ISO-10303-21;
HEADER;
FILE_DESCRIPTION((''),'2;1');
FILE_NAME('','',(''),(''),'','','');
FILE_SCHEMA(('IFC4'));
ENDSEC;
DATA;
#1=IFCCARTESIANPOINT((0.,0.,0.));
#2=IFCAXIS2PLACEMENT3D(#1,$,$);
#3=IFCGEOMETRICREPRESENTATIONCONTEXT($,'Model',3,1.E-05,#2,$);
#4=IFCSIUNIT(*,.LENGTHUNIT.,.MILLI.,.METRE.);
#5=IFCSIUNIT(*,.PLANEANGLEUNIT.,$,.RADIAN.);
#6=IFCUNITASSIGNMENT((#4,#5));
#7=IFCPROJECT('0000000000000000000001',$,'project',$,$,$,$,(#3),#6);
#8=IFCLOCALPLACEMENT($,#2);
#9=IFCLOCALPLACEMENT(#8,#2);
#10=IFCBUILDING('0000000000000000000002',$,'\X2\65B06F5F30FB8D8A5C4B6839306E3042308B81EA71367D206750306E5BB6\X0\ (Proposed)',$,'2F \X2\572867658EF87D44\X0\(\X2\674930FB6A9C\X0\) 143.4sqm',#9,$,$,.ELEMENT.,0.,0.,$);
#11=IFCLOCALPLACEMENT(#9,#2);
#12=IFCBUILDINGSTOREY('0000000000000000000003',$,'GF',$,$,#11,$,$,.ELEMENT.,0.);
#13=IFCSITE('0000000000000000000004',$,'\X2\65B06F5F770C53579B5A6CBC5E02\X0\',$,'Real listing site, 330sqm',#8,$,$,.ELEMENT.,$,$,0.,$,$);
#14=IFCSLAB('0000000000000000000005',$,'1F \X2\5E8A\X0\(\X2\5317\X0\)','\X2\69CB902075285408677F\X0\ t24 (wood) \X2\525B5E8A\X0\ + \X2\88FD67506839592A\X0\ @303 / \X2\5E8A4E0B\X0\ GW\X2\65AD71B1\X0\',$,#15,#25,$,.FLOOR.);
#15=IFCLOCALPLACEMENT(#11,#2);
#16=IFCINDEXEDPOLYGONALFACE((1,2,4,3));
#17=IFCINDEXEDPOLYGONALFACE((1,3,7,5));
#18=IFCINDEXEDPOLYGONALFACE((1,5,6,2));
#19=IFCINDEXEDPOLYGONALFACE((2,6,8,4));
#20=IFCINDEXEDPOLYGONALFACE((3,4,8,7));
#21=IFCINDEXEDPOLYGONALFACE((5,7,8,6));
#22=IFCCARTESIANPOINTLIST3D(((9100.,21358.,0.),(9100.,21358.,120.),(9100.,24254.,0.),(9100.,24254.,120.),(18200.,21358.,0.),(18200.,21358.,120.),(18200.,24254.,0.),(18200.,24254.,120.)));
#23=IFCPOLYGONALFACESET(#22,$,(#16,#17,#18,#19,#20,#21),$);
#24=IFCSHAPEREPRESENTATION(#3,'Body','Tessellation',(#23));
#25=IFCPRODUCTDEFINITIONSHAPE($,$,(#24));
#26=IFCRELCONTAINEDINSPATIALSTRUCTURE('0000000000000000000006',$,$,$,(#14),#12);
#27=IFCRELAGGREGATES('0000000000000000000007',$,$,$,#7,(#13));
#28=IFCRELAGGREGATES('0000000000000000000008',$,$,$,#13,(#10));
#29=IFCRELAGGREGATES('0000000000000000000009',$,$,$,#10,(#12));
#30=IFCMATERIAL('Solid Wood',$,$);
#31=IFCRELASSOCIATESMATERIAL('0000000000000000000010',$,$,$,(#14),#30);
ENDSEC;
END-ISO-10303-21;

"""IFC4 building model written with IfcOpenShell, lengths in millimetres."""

from ifc_helpers import new_model, si_unit, frame, frame_2d, origin, place, context, project, spatial, rectangle, extrude, material, element, save


model = new_model("IFC4")

# Units and contexts
model_context = context("Model", 3, precision=1e-05, world=origin())
ifc_project = project(units=[si_unit("LENGTHUNIT", "METRE", prefix="MILLI"), si_unit("PLANEANGLEUNIT", "RADIAN")], contexts=[model_context])

# Site, building, storey
site_placement = place(None, origin())
site = spatial("IfcSite", under=ifc_project, at=site_placement, Name="新潟県南魚沼市", ObjectType="Real listing site, 330sqm", CompositionType="ELEMENT", RefElevation=0.0)
building_placement = place(site_placement, origin())
building = spatial("IfcBuilding", under=site, at=building_placement, Name="新潟・越屋根のある自然素材の家 (Proposed)", ObjectType="2F 在来軸組(杉・檜) 143.4sqm", CompositionType="ELEMENT", ElevationOfRefHeight=0.0, ElevationOfTerrain=0.0)
storey_placement = place(building_placement, origin())
storey = spatial("IfcBuildingStorey", under=building, at=storey_placement, Name="GF", CompositionType="ELEMENT", Elevation=0.0)

# Shared definitions
ifc_material_1 = material(Name="Solid Wood")

# Slab
slab_1_placement = place(storey_placement, frame((4550.0, 10679.0, 0.0)))
element("IfcSlab", 1, at=slab_1_placement, inside=storey, material=ifc_material_1, Name="1F 床(北)", Description="構造用合板 t24 (wood) 剛床 + 製材根太 @303 / 床下 GW断熱", PredefinedType="FLOOR", context=model_context, shape_type="SweptSolid", body=[
    extrude(rectangle(XDim=9100.0, YDim=2896.0, at=frame_2d((4550.0, 1448.0))), frame((4550.0, 10679.0, 0.0)), (0.0, 0.0, 1.0), 120.0),
])

save(model, "model.ifc")
